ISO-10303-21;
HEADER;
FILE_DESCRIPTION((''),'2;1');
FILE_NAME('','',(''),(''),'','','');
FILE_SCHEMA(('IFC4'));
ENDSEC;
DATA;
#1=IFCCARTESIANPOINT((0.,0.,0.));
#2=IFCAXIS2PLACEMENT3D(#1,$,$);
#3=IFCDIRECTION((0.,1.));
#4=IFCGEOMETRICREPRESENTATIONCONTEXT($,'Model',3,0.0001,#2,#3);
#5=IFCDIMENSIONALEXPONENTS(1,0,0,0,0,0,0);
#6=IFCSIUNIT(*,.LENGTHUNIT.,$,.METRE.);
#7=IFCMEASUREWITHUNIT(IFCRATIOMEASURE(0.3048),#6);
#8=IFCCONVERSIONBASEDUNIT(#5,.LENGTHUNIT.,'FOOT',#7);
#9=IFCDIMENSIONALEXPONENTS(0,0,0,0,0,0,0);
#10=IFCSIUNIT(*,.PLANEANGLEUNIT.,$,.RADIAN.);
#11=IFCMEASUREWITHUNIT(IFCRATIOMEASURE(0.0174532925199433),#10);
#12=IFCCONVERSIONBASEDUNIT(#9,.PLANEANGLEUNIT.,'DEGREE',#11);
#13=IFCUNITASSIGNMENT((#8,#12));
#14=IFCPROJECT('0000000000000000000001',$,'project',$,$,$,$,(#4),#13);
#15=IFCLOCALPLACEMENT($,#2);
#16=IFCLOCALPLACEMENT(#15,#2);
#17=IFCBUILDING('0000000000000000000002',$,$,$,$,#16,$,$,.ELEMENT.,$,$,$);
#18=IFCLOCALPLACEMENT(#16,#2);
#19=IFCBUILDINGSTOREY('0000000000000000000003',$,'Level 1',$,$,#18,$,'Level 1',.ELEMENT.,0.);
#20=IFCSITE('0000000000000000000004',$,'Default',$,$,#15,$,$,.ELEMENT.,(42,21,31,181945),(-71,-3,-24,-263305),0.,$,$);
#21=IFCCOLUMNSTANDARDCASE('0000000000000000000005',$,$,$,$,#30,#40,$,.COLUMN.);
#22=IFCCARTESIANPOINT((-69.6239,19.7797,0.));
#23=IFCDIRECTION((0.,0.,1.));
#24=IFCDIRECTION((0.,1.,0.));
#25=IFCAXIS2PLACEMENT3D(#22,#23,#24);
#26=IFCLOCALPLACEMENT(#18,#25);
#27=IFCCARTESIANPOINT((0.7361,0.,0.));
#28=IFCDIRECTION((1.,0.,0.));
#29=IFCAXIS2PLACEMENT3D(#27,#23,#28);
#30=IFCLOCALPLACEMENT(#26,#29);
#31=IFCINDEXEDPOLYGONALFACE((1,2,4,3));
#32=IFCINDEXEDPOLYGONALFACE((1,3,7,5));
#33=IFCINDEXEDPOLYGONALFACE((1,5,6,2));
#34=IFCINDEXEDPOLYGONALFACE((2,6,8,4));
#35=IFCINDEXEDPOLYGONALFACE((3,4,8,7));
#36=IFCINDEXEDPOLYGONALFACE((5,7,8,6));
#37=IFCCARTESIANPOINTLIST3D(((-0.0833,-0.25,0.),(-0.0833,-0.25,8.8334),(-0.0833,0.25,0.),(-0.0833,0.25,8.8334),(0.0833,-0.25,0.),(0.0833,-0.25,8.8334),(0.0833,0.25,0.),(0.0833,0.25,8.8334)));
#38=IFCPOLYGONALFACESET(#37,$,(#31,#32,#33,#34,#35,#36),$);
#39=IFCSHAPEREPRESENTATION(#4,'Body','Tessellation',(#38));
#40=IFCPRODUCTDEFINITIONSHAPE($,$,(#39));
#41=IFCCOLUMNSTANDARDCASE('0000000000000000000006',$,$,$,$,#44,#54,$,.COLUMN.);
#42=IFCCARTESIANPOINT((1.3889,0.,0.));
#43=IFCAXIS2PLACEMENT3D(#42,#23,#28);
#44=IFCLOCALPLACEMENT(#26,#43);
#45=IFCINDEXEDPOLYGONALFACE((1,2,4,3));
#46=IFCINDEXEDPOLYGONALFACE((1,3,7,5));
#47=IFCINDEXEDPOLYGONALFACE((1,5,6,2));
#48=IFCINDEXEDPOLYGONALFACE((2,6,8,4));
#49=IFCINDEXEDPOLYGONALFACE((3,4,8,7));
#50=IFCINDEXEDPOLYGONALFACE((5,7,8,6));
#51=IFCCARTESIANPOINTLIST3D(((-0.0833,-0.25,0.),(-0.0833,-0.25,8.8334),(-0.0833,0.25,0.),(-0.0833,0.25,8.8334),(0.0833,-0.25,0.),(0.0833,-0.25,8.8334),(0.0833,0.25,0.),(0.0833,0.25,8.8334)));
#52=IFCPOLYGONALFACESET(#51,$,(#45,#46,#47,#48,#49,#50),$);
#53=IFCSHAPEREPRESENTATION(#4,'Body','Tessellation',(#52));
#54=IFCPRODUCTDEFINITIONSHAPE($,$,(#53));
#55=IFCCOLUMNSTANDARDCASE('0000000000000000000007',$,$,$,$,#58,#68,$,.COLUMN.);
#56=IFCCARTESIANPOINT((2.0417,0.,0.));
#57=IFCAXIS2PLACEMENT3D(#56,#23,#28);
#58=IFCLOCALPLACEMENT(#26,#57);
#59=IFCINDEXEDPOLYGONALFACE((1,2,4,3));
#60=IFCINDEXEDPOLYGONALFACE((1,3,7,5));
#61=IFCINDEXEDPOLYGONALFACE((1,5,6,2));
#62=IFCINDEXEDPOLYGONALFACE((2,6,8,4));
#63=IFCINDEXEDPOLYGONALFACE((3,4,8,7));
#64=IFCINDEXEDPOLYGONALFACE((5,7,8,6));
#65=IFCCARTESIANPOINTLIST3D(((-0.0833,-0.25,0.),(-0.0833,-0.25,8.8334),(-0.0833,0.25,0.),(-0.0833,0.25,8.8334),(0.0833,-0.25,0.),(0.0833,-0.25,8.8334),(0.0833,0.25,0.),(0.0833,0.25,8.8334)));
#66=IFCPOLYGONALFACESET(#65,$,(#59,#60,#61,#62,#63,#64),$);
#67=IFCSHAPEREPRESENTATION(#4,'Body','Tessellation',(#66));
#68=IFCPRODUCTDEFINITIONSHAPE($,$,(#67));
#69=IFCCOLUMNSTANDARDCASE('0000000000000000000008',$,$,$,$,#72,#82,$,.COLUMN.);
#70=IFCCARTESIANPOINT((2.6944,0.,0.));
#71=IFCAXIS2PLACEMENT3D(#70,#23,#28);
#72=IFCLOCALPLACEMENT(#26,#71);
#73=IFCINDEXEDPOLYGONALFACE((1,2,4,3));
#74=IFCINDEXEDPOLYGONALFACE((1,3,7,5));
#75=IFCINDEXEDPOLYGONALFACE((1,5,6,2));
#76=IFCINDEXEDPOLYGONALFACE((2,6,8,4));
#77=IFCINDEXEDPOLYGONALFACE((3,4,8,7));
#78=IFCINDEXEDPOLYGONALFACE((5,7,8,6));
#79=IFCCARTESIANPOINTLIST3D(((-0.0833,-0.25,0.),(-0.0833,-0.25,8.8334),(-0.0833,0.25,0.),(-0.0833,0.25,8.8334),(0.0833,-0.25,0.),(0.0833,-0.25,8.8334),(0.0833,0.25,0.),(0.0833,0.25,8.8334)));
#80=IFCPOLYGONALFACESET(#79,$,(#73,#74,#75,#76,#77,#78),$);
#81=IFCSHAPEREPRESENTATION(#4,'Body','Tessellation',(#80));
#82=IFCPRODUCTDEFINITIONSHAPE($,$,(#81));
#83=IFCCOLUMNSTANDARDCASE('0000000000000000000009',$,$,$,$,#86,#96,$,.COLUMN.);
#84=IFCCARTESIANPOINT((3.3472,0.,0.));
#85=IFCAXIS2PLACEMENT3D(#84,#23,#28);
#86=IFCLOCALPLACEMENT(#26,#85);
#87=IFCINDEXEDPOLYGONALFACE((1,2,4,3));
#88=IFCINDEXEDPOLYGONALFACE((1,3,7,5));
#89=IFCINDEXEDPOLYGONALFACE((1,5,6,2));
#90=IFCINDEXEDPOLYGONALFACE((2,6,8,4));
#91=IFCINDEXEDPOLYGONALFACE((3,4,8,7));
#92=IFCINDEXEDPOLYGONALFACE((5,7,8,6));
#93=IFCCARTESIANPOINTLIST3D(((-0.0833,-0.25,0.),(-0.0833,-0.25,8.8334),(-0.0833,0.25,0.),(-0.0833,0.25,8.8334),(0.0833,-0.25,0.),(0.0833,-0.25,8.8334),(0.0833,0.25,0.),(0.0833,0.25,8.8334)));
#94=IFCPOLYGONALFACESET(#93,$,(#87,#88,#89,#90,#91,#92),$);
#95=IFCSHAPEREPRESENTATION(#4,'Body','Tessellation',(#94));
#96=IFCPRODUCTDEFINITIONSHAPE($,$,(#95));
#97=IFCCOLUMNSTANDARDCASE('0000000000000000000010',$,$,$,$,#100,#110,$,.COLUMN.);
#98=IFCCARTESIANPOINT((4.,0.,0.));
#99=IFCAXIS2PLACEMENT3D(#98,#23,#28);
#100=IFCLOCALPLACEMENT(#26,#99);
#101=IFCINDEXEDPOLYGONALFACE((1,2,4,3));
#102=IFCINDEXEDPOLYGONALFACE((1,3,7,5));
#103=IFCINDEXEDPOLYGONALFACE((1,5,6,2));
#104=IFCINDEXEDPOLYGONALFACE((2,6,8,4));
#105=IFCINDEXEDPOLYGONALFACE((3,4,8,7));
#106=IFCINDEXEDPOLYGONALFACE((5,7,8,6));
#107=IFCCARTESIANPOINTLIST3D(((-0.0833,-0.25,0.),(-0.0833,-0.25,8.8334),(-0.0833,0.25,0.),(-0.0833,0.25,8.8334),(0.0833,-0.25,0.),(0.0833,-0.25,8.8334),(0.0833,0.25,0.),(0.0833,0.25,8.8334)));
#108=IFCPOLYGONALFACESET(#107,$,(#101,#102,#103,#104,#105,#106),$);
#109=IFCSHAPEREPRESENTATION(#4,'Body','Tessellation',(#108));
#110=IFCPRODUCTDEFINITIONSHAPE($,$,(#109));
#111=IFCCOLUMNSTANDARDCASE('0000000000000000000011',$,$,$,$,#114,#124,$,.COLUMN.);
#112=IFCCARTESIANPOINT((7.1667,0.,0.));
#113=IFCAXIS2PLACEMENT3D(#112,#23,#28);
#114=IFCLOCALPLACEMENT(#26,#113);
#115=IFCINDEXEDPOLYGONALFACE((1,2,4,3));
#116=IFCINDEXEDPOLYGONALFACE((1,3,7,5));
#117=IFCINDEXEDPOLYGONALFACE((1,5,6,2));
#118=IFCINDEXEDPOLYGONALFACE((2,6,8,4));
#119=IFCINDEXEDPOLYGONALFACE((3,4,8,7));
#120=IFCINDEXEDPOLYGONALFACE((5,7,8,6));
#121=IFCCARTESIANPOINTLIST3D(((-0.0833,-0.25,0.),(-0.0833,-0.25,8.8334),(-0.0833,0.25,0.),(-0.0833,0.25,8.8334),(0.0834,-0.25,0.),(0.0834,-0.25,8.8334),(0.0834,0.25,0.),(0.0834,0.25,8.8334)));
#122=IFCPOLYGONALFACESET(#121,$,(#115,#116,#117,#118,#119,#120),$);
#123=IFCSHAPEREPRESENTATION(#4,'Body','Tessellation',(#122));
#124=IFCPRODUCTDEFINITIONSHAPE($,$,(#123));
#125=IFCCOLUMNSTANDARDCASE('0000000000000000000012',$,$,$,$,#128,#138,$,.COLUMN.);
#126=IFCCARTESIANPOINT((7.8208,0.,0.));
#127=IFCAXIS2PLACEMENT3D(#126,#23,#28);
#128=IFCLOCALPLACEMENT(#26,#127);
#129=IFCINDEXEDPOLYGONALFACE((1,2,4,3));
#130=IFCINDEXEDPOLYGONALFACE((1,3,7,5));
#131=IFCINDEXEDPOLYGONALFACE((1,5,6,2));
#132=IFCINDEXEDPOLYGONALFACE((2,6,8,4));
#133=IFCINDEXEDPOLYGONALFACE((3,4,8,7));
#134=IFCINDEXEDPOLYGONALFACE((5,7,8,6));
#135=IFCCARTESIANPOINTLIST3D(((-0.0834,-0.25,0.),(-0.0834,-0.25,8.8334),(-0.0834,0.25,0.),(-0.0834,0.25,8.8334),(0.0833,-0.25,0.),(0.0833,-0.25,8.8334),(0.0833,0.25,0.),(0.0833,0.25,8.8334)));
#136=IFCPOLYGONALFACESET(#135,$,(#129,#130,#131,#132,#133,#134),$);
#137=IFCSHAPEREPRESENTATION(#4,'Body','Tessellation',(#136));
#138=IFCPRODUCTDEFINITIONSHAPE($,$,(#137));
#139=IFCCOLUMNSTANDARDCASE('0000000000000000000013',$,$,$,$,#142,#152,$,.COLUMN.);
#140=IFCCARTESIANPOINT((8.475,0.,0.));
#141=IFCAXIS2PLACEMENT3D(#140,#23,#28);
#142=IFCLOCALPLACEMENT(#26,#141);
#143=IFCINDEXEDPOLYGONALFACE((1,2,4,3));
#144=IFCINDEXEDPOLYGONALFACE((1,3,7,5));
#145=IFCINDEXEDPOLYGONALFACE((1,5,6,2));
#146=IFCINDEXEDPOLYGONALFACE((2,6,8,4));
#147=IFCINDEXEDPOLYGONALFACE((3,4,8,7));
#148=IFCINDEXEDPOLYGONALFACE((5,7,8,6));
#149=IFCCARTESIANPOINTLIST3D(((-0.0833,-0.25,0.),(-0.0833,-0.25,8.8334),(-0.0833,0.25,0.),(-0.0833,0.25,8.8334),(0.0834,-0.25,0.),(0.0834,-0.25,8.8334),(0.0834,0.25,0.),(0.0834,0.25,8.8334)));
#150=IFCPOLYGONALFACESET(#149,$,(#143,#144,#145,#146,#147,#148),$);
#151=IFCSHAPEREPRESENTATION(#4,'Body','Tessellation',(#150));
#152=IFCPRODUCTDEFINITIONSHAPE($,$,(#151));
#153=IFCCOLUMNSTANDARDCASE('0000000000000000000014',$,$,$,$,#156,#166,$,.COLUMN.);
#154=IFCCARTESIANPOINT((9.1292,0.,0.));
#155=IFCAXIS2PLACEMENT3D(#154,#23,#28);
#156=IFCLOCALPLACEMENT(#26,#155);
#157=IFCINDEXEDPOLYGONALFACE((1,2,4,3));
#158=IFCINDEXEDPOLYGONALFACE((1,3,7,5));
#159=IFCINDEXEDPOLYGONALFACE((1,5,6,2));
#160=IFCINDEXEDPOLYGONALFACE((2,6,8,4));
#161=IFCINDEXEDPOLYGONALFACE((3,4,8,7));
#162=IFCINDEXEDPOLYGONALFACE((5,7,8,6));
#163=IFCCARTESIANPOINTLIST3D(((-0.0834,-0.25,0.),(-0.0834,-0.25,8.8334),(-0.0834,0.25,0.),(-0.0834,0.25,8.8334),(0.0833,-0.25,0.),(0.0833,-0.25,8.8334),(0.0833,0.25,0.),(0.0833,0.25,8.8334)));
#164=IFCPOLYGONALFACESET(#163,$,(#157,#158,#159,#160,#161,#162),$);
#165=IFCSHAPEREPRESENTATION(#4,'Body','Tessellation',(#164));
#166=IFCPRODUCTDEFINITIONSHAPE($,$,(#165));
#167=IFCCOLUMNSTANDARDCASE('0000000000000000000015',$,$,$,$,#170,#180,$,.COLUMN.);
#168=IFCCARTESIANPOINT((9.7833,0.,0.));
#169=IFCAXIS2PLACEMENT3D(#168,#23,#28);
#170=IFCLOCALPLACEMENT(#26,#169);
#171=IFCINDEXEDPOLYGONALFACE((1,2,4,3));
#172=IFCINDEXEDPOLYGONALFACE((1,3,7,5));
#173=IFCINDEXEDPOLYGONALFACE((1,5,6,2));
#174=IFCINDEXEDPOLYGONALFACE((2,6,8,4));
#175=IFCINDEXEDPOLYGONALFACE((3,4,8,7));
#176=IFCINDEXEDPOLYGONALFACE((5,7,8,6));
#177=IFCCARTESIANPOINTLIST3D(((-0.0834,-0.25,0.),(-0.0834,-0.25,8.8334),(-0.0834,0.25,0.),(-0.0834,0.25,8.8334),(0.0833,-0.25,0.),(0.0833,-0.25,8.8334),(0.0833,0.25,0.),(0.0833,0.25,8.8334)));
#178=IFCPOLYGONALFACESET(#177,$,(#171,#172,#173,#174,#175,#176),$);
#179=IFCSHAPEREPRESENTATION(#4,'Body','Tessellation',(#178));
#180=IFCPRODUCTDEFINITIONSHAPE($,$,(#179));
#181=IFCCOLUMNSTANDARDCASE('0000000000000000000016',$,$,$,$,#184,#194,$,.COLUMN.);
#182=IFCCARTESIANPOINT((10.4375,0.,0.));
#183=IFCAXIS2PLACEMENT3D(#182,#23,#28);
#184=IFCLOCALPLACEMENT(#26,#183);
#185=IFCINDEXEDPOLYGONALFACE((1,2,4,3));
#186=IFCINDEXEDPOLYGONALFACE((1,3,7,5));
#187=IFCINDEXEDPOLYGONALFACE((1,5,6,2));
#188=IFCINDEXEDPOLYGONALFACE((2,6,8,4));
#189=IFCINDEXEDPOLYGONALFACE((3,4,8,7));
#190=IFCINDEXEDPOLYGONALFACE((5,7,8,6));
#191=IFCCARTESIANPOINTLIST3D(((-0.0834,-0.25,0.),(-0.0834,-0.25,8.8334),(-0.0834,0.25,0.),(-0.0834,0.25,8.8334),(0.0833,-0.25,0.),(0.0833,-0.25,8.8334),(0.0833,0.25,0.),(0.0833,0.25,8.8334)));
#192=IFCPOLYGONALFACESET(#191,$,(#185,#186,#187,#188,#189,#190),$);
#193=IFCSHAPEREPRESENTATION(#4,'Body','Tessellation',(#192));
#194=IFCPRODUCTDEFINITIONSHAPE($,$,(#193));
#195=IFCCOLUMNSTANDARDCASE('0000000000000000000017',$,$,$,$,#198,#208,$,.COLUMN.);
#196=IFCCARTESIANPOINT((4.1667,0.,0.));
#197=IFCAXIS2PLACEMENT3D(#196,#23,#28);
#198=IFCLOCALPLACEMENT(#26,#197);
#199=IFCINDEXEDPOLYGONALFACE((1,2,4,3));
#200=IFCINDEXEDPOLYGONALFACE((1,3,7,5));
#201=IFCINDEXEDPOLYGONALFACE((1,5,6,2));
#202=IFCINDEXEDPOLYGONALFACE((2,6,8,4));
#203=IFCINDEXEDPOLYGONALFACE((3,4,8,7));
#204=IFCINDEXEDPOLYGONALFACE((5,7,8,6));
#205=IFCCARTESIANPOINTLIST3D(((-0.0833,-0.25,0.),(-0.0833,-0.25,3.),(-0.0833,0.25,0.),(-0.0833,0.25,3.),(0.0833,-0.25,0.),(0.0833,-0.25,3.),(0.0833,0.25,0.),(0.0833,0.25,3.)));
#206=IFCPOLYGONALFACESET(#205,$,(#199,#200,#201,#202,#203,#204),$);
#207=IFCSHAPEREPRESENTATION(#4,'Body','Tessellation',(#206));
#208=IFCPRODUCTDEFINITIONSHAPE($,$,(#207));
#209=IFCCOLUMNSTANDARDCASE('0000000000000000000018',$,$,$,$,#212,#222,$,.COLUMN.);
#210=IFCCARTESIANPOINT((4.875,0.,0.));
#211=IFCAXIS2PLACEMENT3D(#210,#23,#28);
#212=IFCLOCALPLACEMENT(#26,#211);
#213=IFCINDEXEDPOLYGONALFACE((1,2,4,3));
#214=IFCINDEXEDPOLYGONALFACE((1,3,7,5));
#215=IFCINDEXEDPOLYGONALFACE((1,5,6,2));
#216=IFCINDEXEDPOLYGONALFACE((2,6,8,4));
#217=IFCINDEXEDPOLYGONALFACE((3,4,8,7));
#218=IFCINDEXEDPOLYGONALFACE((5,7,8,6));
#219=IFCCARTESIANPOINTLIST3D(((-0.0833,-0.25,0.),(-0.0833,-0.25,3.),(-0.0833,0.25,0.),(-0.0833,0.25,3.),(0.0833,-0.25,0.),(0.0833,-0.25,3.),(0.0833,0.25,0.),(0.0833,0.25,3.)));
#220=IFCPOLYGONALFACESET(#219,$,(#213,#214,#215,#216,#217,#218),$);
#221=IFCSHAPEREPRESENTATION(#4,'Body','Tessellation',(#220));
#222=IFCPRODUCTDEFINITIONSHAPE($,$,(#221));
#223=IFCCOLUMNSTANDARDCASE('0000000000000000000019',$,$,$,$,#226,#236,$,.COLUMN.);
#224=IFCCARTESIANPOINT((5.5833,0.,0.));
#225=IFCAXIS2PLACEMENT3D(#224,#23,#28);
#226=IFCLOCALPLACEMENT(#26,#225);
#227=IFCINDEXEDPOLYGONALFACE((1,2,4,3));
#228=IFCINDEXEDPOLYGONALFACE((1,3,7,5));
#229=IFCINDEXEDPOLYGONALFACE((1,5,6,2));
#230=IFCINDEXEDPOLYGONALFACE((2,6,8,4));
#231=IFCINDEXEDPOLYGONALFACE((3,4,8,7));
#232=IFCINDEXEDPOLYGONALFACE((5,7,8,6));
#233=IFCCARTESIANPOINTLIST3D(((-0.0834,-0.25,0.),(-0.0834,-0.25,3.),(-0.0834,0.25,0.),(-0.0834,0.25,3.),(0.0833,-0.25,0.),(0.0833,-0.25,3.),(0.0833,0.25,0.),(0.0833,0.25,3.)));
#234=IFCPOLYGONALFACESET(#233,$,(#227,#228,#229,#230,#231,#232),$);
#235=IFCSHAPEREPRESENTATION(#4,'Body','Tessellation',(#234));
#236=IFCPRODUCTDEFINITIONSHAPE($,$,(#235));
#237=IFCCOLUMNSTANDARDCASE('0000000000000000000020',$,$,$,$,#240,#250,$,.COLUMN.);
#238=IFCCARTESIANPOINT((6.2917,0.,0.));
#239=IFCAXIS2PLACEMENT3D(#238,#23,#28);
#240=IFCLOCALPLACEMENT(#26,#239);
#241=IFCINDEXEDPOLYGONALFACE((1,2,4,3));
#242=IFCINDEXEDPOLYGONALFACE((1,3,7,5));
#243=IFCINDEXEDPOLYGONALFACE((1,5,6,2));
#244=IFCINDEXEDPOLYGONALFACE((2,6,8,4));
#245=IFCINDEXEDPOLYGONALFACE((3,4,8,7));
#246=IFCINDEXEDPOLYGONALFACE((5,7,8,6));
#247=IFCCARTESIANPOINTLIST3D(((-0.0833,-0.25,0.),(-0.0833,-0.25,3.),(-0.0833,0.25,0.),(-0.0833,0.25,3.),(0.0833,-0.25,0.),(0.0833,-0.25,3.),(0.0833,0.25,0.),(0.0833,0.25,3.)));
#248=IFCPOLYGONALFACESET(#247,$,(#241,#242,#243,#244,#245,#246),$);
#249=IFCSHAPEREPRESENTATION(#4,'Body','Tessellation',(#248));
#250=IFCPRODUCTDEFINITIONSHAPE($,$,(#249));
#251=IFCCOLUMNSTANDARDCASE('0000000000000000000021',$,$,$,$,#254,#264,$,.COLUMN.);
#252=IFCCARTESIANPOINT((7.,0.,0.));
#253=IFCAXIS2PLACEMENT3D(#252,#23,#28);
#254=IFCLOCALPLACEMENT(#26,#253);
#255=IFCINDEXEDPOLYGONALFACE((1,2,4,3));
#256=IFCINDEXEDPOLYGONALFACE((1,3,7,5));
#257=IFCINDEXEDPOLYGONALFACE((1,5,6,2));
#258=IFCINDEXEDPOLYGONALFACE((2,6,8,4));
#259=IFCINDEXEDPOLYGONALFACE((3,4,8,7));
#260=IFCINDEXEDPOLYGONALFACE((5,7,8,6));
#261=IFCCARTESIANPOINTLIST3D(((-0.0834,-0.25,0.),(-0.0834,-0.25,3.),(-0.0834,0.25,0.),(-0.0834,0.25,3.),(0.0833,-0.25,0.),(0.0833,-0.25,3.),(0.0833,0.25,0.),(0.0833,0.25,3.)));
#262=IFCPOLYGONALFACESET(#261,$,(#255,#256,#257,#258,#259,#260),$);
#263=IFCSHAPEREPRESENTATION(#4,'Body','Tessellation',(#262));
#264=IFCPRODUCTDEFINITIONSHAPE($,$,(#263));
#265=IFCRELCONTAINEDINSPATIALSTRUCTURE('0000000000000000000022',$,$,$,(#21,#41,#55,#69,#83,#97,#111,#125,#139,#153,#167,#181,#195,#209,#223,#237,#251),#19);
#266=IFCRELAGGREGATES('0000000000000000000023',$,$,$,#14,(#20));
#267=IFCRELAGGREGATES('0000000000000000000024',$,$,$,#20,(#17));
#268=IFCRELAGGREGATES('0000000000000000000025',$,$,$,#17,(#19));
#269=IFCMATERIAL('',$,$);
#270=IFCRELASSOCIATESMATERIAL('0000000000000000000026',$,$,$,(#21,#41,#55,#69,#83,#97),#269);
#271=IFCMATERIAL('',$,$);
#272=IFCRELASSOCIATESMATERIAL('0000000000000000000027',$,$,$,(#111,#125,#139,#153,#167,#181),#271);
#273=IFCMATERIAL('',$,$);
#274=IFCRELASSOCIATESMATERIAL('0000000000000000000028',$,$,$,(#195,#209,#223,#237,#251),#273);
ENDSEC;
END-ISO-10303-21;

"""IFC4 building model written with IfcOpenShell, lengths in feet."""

from ifc_helpers import new_model, entity, si_unit, converted_unit, direction, frame, origin, place, context, project, spatial, rectangle, extrude, material, element, save


model = new_model("IFC4")

# Units and contexts
model_context = context("Model", 3, precision=0.0001, world=origin(), true_north=direction((0.0, 1.0)))
ifc_project = project(units=[converted_unit("LENGTHUNIT", "FOOT", entity("IfcRatioMeasure", 0.3048), si_unit("LENGTHUNIT", "METRE"), dimensions=[1, 0, 0, 0, 0, 0, 0]), converted_unit("PLANEANGLEUNIT", "DEGREE", entity("IfcRatioMeasure", 0.0174532925199433), si_unit("PLANEANGLEUNIT", "RADIAN"), dimensions=[0, 0, 0, 0, 0, 0, 0])], contexts=[model_context])

# Site, building, storey
site_placement = place(None, origin())
site = spatial("IfcSite", under=ifc_project, at=site_placement, Name="Default", CompositionType="ELEMENT", RefLatitude=(42, 21, 31, 181945), RefLongitude=(-71, -3, -24, -263305), RefElevation=0.0)
building_placement = place(site_placement, origin())
building = spatial("IfcBuilding", under=site, at=building_placement, CompositionType="ELEMENT")
storey_placement = place(building_placement, origin())
storey = spatial("IfcBuildingStorey", under=building, at=storey_placement, Name="Level 1", LongName="Level 1", CompositionType="ELEMENT", Elevation=0.0)

# Columns
ifc_material_1 = material(Name="")
placement_1 = place(storey_placement, frame((-69.6239, 19.7797, 0.0), z_axis=(0.0, 0.0, 1.0), x_axis=(0.0, 1.0, 0.0)))
for number, where, z_axis, x_axis in (
    (1, (0.7361, 0.0, 0.0), (0.0, 0.0, 1.0), (1.0, 0.0, 0.0)),
    (2, (1.3889, 0.0, 0.0), (0.0, 0.0, 1.0), (1.0, 0.0, 0.0)),
    (3, (2.0417, 0.0, 0.0), (0.0, 0.0, 1.0), (1.0, 0.0, 0.0)),
    (4, (2.6944, 0.0, 0.0), (0.0, 0.0, 1.0), (1.0, 0.0, 0.0)),
    (5, (3.3472, 0.0, 0.0), (0.0, 0.0, 1.0), (1.0, 0.0, 0.0)),
    (6, (4.0, 0.0, 0.0), (0.0, 0.0, 1.0), (1.0, 0.0, 0.0)),
):
    element("IfcColumnStandardCase", number, at=place(placement_1, frame(where, z_axis=z_axis, x_axis=x_axis)), inside=storey, material=ifc_material_1, PredefinedType="COLUMN", context=model_context, shape_type="SweptSolid", body=[
        extrude(rectangle(XDim=0.1667, YDim=0.5), origin(), (0.0, 0.0, 1.0), 8.8334),
    ])
ifc_material_2 = material(Name="")
for number, where, z_axis, x_axis in (
    (7, (7.1667, 0.0, 0.0), (0.0, 0.0, 1.0), (1.0, 0.0, 0.0)),
    (8, (7.8208, 0.0, 0.0), (0.0, 0.0, 1.0), (1.0, 0.0, 0.0)),
    (9, (8.475, 0.0, 0.0), (0.0, 0.0, 1.0), (1.0, 0.0, 0.0)),
    (10, (9.1292, 0.0, 0.0), (0.0, 0.0, 1.0), (1.0, 0.0, 0.0)),
    (11, (9.7833, 0.0, 0.0), (0.0, 0.0, 1.0), (1.0, 0.0, 0.0)),
    (12, (10.4375, 0.0, 0.0), (0.0, 0.0, 1.0), (1.0, 0.0, 0.0)),
):
    element("IfcColumnStandardCase", number, at=place(placement_1, frame(where, z_axis=z_axis, x_axis=x_axis)), inside=storey, material=ifc_material_2, PredefinedType="COLUMN", context=model_context, shape_type="SweptSolid", body=[
        extrude(rectangle(XDim=0.1667, YDim=0.5), origin(), (0.0, 0.0, 1.0), 8.8334),
    ])
ifc_material_3 = material(Name="")
for number, where, z_axis, x_axis in (
    (13, (4.1667, 0.0, 0.0), (0.0, 0.0, 1.0), (1.0, 0.0, 0.0)),
    (14, (4.875, 0.0, 0.0), (0.0, 0.0, 1.0), (1.0, 0.0, 0.0)),
    (15, (5.5833, 0.0, 0.0), (0.0, 0.0, 1.0), (1.0, 0.0, 0.0)),
    (16, (6.2917, 0.0, 0.0), (0.0, 0.0, 1.0), (1.0, 0.0, 0.0)),
    (17, (7.0, 0.0, 0.0), (0.0, 0.0, 1.0), (1.0, 0.0, 0.0)),
):
    element("IfcColumnStandardCase", number, at=place(placement_1, frame(where, z_axis=z_axis, x_axis=x_axis)), inside=storey, material=ifc_material_3, PredefinedType="COLUMN", context=model_context, shape_type="SweptSolid", body=[
        extrude(rectangle(XDim=0.1667, YDim=0.5), origin(), (0.0, 0.0, 1.0), 3.0),
    ])

save(model, "model.ifc")
